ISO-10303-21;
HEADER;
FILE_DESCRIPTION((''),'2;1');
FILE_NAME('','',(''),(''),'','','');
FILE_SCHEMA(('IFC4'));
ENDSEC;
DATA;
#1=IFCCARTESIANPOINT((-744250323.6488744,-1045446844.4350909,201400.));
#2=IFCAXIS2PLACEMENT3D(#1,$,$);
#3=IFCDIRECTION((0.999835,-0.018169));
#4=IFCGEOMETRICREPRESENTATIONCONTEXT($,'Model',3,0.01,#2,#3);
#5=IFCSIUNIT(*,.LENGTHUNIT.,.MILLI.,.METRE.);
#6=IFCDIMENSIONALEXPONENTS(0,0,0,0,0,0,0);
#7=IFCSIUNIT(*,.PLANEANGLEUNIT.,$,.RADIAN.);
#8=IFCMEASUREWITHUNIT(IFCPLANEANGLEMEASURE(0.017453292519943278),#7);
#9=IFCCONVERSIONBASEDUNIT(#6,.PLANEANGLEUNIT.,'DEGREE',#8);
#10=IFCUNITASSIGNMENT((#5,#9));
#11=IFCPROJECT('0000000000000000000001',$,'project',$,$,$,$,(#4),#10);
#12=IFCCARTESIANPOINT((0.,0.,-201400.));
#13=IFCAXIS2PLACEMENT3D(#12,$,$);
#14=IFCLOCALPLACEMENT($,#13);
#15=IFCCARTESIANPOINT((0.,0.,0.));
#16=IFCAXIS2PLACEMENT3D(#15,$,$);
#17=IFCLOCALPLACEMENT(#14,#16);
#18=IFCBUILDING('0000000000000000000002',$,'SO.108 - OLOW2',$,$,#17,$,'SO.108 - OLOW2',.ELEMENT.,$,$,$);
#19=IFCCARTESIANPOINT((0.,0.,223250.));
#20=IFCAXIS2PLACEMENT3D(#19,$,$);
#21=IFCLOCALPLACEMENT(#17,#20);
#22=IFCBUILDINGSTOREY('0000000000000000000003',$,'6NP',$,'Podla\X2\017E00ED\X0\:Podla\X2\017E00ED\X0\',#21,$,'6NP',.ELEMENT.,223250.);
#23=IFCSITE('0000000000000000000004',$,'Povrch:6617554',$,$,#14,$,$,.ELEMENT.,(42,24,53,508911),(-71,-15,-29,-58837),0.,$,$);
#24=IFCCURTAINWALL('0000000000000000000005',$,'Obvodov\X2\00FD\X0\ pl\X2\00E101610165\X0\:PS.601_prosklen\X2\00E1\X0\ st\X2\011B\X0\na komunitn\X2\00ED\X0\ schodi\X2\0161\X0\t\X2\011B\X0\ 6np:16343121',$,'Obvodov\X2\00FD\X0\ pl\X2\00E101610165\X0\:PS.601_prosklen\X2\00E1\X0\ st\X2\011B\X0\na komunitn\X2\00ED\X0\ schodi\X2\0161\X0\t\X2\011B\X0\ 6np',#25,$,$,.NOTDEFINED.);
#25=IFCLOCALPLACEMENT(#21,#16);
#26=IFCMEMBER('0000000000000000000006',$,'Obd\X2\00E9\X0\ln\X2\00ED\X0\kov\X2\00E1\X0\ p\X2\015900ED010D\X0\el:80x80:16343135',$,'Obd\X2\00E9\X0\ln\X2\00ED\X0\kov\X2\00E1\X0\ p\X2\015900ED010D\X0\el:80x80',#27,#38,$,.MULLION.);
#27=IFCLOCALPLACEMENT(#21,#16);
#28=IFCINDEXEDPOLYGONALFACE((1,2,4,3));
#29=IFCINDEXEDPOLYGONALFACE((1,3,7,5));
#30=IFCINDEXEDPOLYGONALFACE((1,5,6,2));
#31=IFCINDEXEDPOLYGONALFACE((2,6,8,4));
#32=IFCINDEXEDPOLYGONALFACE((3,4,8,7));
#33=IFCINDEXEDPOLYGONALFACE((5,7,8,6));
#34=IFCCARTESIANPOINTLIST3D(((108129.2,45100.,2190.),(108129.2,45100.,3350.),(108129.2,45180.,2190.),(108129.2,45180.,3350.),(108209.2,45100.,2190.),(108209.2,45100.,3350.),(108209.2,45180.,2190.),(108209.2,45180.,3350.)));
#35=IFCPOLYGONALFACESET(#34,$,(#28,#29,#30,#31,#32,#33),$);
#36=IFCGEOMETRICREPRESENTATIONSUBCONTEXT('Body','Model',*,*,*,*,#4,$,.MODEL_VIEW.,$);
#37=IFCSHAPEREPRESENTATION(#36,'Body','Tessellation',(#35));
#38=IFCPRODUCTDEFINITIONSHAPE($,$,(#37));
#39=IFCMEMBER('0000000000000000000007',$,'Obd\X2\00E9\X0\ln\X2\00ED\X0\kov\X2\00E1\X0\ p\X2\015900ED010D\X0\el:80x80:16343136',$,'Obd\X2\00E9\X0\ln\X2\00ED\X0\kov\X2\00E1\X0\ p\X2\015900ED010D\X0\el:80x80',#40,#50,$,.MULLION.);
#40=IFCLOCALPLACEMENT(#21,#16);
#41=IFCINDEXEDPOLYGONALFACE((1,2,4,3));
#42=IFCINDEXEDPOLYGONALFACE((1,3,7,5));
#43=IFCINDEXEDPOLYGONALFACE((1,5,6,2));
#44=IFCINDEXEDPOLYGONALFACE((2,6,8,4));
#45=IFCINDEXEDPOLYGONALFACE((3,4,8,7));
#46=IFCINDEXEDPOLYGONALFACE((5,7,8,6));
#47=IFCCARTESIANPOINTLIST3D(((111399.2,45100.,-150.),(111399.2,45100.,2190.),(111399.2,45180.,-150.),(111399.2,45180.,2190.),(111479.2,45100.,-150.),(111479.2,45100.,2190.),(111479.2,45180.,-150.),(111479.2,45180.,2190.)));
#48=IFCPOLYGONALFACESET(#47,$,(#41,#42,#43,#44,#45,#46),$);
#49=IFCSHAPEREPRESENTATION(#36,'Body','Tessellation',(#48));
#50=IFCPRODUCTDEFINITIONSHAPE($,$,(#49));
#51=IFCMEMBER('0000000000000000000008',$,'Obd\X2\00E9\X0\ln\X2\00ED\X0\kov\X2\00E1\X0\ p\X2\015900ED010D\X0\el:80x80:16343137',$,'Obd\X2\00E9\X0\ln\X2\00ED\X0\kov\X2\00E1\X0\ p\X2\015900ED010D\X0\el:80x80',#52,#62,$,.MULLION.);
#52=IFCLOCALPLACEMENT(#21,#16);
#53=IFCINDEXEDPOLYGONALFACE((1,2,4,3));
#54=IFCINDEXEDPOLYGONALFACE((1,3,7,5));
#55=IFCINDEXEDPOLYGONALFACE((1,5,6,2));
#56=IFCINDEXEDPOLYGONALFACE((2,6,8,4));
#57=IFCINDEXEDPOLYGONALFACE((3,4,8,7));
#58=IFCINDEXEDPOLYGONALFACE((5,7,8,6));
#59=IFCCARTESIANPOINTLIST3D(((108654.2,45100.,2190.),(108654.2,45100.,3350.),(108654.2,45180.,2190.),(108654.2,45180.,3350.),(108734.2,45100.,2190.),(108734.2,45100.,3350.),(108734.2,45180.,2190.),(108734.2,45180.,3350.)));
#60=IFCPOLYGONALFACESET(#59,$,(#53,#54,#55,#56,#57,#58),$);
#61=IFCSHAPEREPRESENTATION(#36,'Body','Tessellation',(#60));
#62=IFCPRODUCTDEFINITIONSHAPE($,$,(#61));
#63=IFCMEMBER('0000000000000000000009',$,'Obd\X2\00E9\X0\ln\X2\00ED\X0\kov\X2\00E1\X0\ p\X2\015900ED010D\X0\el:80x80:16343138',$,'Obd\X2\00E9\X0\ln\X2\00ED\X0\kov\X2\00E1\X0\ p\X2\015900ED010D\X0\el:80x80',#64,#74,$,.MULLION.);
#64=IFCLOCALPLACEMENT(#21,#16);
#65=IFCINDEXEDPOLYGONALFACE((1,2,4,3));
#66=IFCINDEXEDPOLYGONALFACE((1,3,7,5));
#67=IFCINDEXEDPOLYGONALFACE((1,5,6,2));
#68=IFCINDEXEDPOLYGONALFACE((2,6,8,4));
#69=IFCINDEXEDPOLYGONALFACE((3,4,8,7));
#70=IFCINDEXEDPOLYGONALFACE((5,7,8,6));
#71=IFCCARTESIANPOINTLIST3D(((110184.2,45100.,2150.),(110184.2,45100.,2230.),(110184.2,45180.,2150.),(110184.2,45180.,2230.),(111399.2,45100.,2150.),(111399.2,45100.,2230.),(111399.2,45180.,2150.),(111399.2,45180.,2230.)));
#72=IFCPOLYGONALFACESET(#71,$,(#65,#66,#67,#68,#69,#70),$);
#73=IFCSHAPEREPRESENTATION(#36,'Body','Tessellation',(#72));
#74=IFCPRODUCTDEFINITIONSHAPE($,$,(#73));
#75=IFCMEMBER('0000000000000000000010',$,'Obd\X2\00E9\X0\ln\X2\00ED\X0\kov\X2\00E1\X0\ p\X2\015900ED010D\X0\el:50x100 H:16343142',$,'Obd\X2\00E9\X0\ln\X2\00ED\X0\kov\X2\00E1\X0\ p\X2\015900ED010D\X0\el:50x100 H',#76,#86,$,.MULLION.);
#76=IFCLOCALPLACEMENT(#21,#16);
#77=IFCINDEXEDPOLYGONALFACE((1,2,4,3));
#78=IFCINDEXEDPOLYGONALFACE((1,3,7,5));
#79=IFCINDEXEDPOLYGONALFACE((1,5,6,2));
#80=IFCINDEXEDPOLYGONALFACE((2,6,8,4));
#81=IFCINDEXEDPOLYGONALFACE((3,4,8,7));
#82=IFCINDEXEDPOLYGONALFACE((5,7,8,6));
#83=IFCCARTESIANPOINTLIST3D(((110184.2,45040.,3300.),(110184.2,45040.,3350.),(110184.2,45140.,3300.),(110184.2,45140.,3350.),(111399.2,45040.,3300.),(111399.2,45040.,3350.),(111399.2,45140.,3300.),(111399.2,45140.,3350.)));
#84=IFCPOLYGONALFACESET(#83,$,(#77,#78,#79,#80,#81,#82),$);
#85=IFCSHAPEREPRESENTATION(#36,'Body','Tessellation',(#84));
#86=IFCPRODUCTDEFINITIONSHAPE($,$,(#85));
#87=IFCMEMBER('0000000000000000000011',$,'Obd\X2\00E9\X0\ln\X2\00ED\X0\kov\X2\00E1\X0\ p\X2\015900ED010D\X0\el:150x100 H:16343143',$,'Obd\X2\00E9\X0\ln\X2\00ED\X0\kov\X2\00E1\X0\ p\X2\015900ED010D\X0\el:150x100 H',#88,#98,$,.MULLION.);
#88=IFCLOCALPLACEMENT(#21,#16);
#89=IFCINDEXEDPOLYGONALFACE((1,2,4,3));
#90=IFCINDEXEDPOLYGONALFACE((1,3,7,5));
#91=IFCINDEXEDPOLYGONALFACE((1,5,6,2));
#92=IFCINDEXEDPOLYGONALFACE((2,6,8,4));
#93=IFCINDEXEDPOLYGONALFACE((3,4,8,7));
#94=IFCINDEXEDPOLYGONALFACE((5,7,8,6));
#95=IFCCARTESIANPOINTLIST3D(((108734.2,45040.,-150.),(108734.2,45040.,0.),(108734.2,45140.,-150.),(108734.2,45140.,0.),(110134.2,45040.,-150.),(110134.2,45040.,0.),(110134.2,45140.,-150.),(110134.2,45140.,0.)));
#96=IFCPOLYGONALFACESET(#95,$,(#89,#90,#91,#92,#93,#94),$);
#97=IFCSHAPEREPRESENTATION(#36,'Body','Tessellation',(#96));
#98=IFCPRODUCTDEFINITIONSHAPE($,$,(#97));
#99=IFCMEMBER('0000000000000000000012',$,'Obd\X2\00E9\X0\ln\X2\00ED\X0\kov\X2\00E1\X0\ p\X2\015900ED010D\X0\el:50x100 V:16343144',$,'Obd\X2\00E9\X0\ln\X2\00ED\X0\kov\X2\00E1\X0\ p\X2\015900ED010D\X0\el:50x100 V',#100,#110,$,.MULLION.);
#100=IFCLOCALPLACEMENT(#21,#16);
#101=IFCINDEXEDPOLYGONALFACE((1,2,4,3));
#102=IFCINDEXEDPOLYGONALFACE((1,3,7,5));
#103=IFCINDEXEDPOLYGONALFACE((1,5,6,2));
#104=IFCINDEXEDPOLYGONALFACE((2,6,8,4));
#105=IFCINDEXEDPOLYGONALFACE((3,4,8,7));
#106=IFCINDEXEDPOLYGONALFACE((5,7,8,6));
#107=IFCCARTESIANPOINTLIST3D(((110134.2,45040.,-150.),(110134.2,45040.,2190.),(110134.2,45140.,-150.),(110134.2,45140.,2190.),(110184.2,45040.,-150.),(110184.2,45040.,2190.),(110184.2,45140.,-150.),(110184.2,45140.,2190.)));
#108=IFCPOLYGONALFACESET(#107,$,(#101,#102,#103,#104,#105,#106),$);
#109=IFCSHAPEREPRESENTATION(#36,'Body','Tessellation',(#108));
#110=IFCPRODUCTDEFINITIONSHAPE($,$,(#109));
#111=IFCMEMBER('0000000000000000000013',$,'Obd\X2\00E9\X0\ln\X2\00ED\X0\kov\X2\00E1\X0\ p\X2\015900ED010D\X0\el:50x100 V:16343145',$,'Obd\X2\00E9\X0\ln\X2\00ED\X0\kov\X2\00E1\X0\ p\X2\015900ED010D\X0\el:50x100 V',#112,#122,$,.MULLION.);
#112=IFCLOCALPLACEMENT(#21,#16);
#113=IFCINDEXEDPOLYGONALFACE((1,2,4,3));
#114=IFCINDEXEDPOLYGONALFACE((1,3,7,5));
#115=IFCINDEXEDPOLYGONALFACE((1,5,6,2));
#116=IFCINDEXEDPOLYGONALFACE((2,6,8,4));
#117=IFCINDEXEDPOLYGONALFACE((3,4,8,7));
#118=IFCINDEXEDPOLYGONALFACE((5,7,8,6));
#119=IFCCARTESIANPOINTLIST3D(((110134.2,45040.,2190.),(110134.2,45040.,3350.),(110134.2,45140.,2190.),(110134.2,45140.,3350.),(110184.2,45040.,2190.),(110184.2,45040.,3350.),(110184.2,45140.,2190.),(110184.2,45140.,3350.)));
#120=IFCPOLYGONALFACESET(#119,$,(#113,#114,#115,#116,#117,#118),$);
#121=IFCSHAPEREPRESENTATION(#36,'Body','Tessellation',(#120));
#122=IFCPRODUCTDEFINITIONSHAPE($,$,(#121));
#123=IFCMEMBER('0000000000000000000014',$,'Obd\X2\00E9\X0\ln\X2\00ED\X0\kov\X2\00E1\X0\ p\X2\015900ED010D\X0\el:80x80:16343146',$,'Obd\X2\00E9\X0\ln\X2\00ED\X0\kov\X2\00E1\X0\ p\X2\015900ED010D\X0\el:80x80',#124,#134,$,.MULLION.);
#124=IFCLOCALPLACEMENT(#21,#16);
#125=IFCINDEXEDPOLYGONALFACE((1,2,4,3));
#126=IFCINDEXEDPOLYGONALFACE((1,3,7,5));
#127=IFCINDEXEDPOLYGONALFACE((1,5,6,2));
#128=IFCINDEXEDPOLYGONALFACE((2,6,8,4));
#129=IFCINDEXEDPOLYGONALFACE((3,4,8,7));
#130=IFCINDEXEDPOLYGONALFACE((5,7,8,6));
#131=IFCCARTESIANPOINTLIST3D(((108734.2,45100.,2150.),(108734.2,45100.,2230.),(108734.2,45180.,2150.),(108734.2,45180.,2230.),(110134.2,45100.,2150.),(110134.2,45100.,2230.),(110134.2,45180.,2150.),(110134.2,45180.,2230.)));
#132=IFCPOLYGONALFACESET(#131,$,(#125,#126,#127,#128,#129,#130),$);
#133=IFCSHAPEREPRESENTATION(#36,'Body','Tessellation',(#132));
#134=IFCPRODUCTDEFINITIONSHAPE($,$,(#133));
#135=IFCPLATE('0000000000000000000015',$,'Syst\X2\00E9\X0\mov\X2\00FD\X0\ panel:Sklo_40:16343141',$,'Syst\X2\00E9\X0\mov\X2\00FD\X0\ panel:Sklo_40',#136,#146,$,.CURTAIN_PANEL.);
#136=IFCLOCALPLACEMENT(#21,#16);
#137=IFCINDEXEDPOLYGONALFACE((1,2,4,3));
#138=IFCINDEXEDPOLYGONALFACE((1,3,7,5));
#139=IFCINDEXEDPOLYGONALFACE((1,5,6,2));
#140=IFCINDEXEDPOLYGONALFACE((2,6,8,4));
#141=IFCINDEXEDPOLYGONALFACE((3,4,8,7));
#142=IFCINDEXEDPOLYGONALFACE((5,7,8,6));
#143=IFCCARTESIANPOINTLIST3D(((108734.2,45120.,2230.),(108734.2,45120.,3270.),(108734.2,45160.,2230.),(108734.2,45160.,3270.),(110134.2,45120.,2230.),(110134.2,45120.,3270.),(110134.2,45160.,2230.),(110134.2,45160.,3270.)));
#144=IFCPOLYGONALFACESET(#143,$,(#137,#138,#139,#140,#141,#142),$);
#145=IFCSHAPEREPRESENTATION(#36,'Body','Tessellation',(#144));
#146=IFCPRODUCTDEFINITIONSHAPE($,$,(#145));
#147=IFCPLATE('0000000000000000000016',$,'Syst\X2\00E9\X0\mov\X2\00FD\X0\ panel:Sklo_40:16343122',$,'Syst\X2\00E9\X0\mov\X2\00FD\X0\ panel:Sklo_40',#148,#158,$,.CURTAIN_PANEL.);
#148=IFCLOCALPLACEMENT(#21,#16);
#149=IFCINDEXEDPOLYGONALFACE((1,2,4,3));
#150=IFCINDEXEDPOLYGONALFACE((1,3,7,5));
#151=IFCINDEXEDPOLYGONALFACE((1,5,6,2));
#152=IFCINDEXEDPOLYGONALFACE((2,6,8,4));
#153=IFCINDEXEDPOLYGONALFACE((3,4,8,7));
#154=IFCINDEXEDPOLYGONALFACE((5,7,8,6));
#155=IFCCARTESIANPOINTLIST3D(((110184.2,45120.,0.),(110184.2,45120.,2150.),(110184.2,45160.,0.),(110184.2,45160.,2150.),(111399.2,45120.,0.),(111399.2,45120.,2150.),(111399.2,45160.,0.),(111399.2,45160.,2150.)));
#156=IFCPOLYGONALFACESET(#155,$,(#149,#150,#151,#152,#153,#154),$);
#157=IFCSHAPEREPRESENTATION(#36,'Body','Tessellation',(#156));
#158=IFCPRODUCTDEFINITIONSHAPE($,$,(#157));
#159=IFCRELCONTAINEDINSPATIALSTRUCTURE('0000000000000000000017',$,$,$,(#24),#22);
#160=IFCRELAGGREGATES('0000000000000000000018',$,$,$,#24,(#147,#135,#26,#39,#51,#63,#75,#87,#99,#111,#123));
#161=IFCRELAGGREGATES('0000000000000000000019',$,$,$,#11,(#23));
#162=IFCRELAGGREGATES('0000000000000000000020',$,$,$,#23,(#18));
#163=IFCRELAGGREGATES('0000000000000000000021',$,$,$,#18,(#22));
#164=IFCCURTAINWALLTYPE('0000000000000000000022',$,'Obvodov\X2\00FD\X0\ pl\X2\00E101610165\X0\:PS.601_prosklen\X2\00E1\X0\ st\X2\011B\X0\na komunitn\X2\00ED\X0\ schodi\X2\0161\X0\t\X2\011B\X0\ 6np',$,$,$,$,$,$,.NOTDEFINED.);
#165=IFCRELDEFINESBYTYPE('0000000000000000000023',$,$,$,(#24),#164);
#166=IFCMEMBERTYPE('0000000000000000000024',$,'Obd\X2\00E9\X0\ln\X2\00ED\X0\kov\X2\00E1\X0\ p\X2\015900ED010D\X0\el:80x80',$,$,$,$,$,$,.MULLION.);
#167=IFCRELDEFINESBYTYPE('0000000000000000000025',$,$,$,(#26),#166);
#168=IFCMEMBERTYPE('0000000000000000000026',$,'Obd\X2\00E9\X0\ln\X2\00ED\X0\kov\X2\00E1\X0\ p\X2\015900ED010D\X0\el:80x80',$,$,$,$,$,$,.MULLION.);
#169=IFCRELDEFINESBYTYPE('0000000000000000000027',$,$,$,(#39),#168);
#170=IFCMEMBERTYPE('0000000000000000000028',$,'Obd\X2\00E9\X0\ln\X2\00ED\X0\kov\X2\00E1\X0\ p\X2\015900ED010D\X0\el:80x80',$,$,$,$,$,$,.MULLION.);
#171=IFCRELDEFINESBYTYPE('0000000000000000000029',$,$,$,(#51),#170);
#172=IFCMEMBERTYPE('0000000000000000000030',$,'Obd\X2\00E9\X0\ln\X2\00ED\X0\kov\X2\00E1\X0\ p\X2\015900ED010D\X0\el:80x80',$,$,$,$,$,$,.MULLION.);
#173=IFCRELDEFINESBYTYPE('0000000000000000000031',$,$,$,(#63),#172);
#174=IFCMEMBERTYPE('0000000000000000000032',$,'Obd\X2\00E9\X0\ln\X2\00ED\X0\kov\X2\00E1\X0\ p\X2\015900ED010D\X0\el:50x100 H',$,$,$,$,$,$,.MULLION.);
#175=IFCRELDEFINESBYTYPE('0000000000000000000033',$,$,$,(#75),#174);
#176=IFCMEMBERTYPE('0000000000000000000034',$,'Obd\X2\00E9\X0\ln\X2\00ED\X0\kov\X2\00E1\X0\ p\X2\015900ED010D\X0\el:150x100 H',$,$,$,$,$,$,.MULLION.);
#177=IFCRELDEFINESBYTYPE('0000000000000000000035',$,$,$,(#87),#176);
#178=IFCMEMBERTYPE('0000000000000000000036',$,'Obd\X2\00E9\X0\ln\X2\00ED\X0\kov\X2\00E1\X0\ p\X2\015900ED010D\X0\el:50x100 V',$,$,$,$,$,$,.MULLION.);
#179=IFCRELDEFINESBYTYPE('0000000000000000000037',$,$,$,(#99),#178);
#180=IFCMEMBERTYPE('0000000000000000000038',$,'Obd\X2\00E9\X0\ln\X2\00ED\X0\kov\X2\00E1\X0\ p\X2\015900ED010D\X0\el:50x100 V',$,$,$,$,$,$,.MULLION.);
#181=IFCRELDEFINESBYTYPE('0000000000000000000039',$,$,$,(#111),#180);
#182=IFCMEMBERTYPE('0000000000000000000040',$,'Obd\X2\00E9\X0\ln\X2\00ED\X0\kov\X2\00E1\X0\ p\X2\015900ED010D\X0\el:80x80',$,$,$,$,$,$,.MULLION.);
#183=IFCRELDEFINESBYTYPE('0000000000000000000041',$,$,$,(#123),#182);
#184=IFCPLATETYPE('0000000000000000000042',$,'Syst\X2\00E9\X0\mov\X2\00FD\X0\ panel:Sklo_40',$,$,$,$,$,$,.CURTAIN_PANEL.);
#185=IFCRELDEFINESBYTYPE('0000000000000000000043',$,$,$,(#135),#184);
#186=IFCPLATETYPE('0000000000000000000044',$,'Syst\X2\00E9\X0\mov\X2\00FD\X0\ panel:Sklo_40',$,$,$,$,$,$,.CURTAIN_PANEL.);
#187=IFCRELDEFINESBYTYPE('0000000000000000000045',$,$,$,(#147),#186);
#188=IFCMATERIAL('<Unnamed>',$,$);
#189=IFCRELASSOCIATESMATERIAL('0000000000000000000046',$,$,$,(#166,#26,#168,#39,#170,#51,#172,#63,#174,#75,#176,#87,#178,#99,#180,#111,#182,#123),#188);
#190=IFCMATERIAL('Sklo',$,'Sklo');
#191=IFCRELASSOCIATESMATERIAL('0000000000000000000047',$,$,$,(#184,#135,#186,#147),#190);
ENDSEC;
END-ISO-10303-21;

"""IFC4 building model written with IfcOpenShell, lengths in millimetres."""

from ifc_helpers import new_model, entity, si_unit, converted_unit, direction, frame, origin, place, context, subcontext, project, spatial, indexed_curve, outline, extrude, source, transform, mapped, material, type_object, type_shapes, element, aggregate, save


model = new_model("IFC4")

# Units and contexts
model_context = context("Model", 3, precision=0.01, world=frame((-744250323.6488744, -1045446844.4350909, 201400.0)), true_north=direction((0.999835, -0.018169)))
body_context = subcontext(model_context, "Body", "Model", "MODEL_VIEW")
ifc_project = project(units=[si_unit("LENGTHUNIT", "METRE", prefix="MILLI"), converted_unit("PLANEANGLEUNIT", "DEGREE", entity("IfcPlaneAngleMeasure", 0.017453292519943278), si_unit("PLANEANGLEUNIT", "RADIAN"), dimensions=[0, 0, 0, 0, 0, 0, 0])], contexts=[model_context])

# Site, building, storey
site_placement = place(None, frame((0.0, 0.0, -201400.0)))
site = spatial("IfcSite", under=ifc_project, at=site_placement, Name="Povrch:6617554", CompositionType="ELEMENT", RefLatitude=(42, 24, 53, 508911), RefLongitude=(-71, -15, -29, -58837), RefElevation=0.0)
building_placement = place(site_placement, origin())
building = spatial("IfcBuilding", under=site, at=building_placement, Name="SO.108 - OLOW2", LongName="SO.108 - OLOW2", CompositionType="ELEMENT")
storey_placement = place(building_placement, frame((0.0, 0.0, 223250.0)))
storey = spatial("IfcBuildingStorey", under=building, at=storey_placement, Name="6NP", ObjectType="Podlaží:Podlaží", LongName="6NP", CompositionType="ELEMENT", Elevation=223250.0)

# Shared definitions
ifc_material_1 = material(Name="<Unnamed>")

# Curtain wall, members, plates
curtain_wall_type_1 = type_object("IfcCurtainWallType", Name="Obvodový plášť:PS.601_prosklená stěna komunitní schodiště 6np", PredefinedType="NOTDEFINED")
curtain_wall_1_placement = place(storey_placement, frame((0.0, 0.0, -223250.0)))
curtain_wall_1 = element("IfcCurtainWall", 1, at=curtain_wall_1_placement, inside=storey, type_object=curtain_wall_type_1, Name="Obvodový plášť:PS.601_prosklená stěna komunitní schodiště 6np:16343121", ObjectType="Obvodový plášť:PS.601_prosklená stěna komunitní schodiště 6np", PredefinedType="NOTDEFINED")
member_type_1 = type_object("IfcMemberType", Name="Obdélníková příčel:80x80", PredefinedType="MULLION", material=ifc_material_1)
shared_shape_1 = source(origin(), body_context, "Body", "SweptSolid", [
    extrude(outline(indexed_curve([(-40.0, -40.0), (40.0, -40.0), (40.0, 40.0), (-40.0, 40.0), (-40.0, -40.0)], self_intersect=False)), frame((-40.0, 0.0, -1160.0), z_axis=(0.0, 0.0, 1.0), x_axis=(-1.0, 0.0, 0.0)), (0.0, 0.0, 1.0), 1160.0),
])
type_shapes(member_type_1, [shared_shape_1])
member_1_placement = place(curtain_wall_1_placement, frame((108129.2, 45140.0, 225440.0), z_axis=(0.0, 0.0, -1.0), x_axis=(-1.0, 0.0, 0.0)))
member_1 = element("IfcMember", 2, at=member_1_placement, type_object=member_type_1, material=ifc_material_1, Name="Obdélníková příčel:80x80:16343135", ObjectType="Obdélníková příčel:80x80", PredefinedType="MULLION", context=body_context, shape_type="MappedRepresentation", body=[
    mapped(shared_shape_1, transform((0.0, 0.0, 0.0), scale=1.0)),
])
member_type_2 = type_object("IfcMemberType", Name="Obdélníková příčel:80x80", PredefinedType="MULLION", material=ifc_material_1)
shared_shape_2 = source(origin(), body_context, "Body", "SweptSolid", [
    extrude(outline(indexed_curve([(-40.0, -40.0), (40.0, -40.0), (40.0, 40.0), (-40.0, 40.0), (-40.0, -40.0)], self_intersect=False)), frame((-40.0, 0.0, -2340.0), z_axis=(0.0, 0.0, 1.0), x_axis=(-1.0, 0.0, 0.0)), (0.0, 0.0, 1.0), 2340.0),
])
type_shapes(member_type_2, [shared_shape_2])
member_2_placement = place(curtain_wall_1_placement, frame((111479.2, 45140.0, 225440.0)))
member_2 = element("IfcMember", 3, at=member_2_placement, type_object=member_type_2, material=ifc_material_1, Name="Obdélníková příčel:80x80:16343136", ObjectType="Obdélníková příčel:80x80", PredefinedType="MULLION", context=body_context, shape_type="MappedRepresentation", body=[
    mapped(shared_shape_2, transform((0.0, 0.0, 0.0), scale=1.0)),
])
member_type_3 = type_object("IfcMemberType", Name="Obdélníková příčel:80x80", PredefinedType="MULLION", material=ifc_material_1)
shared_shape_3 = source(origin(), body_context, "Body", "SweptSolid", [
    extrude(outline(indexed_curve([(-40.0, -40.0), (40.0, -40.0), (40.0, 40.0), (-40.0, 40.0), (-40.0, -40.0)], self_intersect=False)), frame((0.0, 0.0, -1160.0), z_axis=(0.0, 0.0, 1.0), x_axis=(-1.0, 0.0, 0.0)), (0.0, 0.0, 1.0), 1160.0),
])
type_shapes(member_type_3, [shared_shape_3])
member_3_placement = place(curtain_wall_1_placement, frame((108694.2, 45140.0, 225440.0), z_axis=(0.0, 0.0, -1.0), x_axis=(-1.0, 0.0, 0.0)))
member_3 = element("IfcMember", 4, at=member_3_placement, type_object=member_type_3, material=ifc_material_1, Name="Obdélníková příčel:80x80:16343137", ObjectType="Obdélníková příčel:80x80", PredefinedType="MULLION", context=body_context, shape_type="MappedRepresentation", body=[
    mapped(shared_shape_3, transform((0.0, 0.0, 0.0), scale=1.0)),
])
member_type_4 = type_object("IfcMemberType", Name="Obdélníková příčel:80x80", PredefinedType="MULLION", material=ifc_material_1)
shared_shape_4 = source(origin(), body_context, "Body", "SweptSolid", [
    extrude(outline(indexed_curve([(-40.0, -40.0), (40.0, -40.0), (40.0, 40.0), (-40.0, 40.0), (-40.0, -40.0)], self_intersect=False)), frame((0.0, 0.0, -1215.0), z_axis=(0.0, 0.0, 1.0), x_axis=(-1.0, 0.0, 0.0)), (0.0, 0.0, 1.0), 1215.0),
])
type_shapes(member_type_4, [shared_shape_4])
member_4_placement = place(curtain_wall_1_placement, frame((110184.2, 45140.0, 225440.0), z_axis=(-1.0, 0.0, 0.0), x_axis=(0.0, 0.0, 1.0)))
member_4 = element("IfcMember", 5, at=member_4_placement, type_object=member_type_4, material=ifc_material_1, Name="Obdélníková příčel:80x80:16343138", ObjectType="Obdélníková příčel:80x80", PredefinedType="MULLION", context=body_context, shape_type="MappedRepresentation", body=[
    mapped(shared_shape_4, transform((0.0, 0.0, 0.0), scale=1.0)),
])
member_type_5 = type_object("IfcMemberType", Name="Obdélníková příčel:50x100 H", PredefinedType="MULLION", material=ifc_material_1)
shared_shape_5 = source(origin(), body_context, "Body", "SweptSolid", [
    extrude(outline(indexed_curve([(-25.0, -50.0), (25.0, -50.0), (25.0, 50.0), (-25.0, 50.0), (-25.0, -50.0)], self_intersect=False)), frame((-25.0, -50.0, -1215.0), z_axis=(0.0, 0.0, 1.0), x_axis=(-1.0, 0.0, 0.0)), (0.0, 0.0, 1.0), 1215.0),
])
type_shapes(member_type_5, [shared_shape_5])
member_5_placement = place(curtain_wall_1_placement, frame((110184.2, 45140.0, 226600.0), z_axis=(-1.0, 0.0, 0.0), x_axis=(0.0, 0.0, 1.0)))
member_5 = element("IfcMember", 6, at=member_5_placement, type_object=member_type_5, material=ifc_material_1, Name="Obdélníková příčel:50x100 H:16343142", ObjectType="Obdélníková příčel:50x100 H", PredefinedType="MULLION", context=body_context, shape_type="MappedRepresentation", body=[
    mapped(shared_shape_5, transform((0.0, 0.0, 0.0), scale=1.0)),
])
member_type_6 = type_object("IfcMemberType", Name="Obdélníková příčel:150x100 H", PredefinedType="MULLION", material=ifc_material_1)
shared_shape_6 = source(origin(), body_context, "Body", "SweptSolid", [
    extrude(outline(indexed_curve([(-75.0, -50.0), (75.0, -50.0), (75.0, 50.0), (-75.0, 50.0), (-75.0, -50.0)], self_intersect=False)), frame((-75.0, -50.0, -1400.0), z_axis=(0.0, 0.0, 1.0), x_axis=(-1.0, 0.0, 0.0)), (0.0, 0.0, 1.0), 1400.0),
])
type_shapes(member_type_6, [shared_shape_6])
member_6_placement = place(curtain_wall_1_placement, frame((110134.2, 45140.0, 223100.0), z_axis=(1.0, 0.0, 0.0), x_axis=(0.0, 0.0, -1.0)))
member_6 = element("IfcMember", 7, at=member_6_placement, type_object=member_type_6, material=ifc_material_1, Name="Obdélníková příčel:150x100 H:16343143", ObjectType="Obdélníková příčel:150x100 H", PredefinedType="MULLION", context=body_context, shape_type="MappedRepresentation", body=[
    mapped(shared_shape_6, transform((0.0, 0.0, 0.0), scale=1.0)),
])
member_type_7 = type_object("IfcMemberType", Name="Obdélníková příčel:50x100 V", PredefinedType="MULLION", material=ifc_material_1)
shared_shape_7 = source(origin(), body_context, "Body", "SweptSolid", [
    extrude(outline(indexed_curve([(-25.0, -50.0), (25.0, -50.0), (25.0, 50.0), (-25.0, 50.0), (-25.0, -50.0)], self_intersect=False)), frame((0.0, -50.0, -2340.0), z_axis=(0.0, 0.0, 1.0), x_axis=(-1.0, 0.0, 0.0)), (0.0, 0.0, 1.0), 2340.0),
])
type_shapes(member_type_7, [shared_shape_7])
member_7_placement = place(curtain_wall_1_placement, frame((110159.2, 45140.0, 223100.0), z_axis=(0.0, 0.0, -1.0), x_axis=(-1.0, 0.0, 0.0)))
member_7 = element("IfcMember", 8, at=member_7_placement, type_object=member_type_7, material=ifc_material_1, Name="Obdélníková příčel:50x100 V:16343144", ObjectType="Obdélníková příčel:50x100 V", PredefinedType="MULLION", context=body_context, shape_type="MappedRepresentation", body=[
    mapped(shared_shape_7, transform((0.0, 0.0, 0.0), scale=1.0)),
])
member_type_8 = type_object("IfcMemberType", Name="Obdélníková příčel:50x100 V", PredefinedType="MULLION", material=ifc_material_1)
shared_shape_8 = source(origin(), body_context, "Body", "SweptSolid", [
    extrude(outline(indexed_curve([(-25.0, -50.0), (25.0, -50.0), (25.0, 50.0), (-25.0, 50.0), (-25.0, -50.0)], self_intersect=False)), frame((0.0, -50.0, -1160.0), z_axis=(0.0, 0.0, 1.0), x_axis=(-1.0, 0.0, 0.0)), (0.0, 0.0, 1.0), 1160.0),
])
type_shapes(member_type_8, [shared_shape_8])
member_8_placement = place(curtain_wall_1_placement, frame((110159.2, 45140.0, 225440.0), z_axis=(0.0, 0.0, -1.0), x_axis=(-1.0, 0.0, 0.0)))
member_8 = element("IfcMember", 9, at=member_8_placement, type_object=member_type_8, material=ifc_material_1, Name="Obdélníková příčel:50x100 V:16343145", ObjectType="Obdélníková příčel:50x100 V", PredefinedType="MULLION", context=body_context, shape_type="MappedRepresentation", body=[
    mapped(shared_shape_8, transform((0.0, 0.0, 0.0), scale=1.0)),
])
member_type_9 = type_object("IfcMemberType", Name="Obdélníková příčel:80x80", PredefinedType="MULLION", material=ifc_material_1)
shared_shape_9 = source(origin(), body_context, "Body", "SweptSolid", [
    extrude(outline(indexed_curve([(-40.0, -40.0), (40.0, -40.0), (40.0, 40.0), (-40.0, 40.0), (-40.0, -40.0)], self_intersect=False)), frame((0.0, 0.0, -1400.0), z_axis=(0.0, 0.0, 1.0), x_axis=(-1.0, 0.0, 0.0)), (0.0, 0.0, 1.0), 1400.0),
])
type_shapes(member_type_9, [shared_shape_9])
member_9_placement = place(curtain_wall_1_placement, frame((108734.2, 45140.0, 225440.0), z_axis=(-1.0, 0.0, 0.0), x_axis=(0.0, 0.0, 1.0)))
member_9 = element("IfcMember", 10, at=member_9_placement, type_object=member_type_9, material=ifc_material_1, Name="Obdélníková příčel:80x80:16343146", ObjectType="Obdélníková příčel:80x80", PredefinedType="MULLION", context=body_context, shape_type="MappedRepresentation", body=[
    mapped(shared_shape_9, transform((0.0, 0.0, 0.0), scale=1.0)),
])
ifc_material_2 = material(Name="Sklo", Category="Sklo")
plate_type_1 = type_object("IfcPlateType", Name="Systémový panel:Sklo_40", PredefinedType="CURTAIN_PANEL", material=ifc_material_2)
shared_shape_10 = source(origin(), body_context, "Body", "SweptSolid", [
    extrude(outline(indexed_curve([(-20.0, -700.0), (20.0, -700.0), (20.0, 700.0), (-20.0, 700.0), (-20.0, -700.0)], self_intersect=False)), frame((0.0, 0.0, 0.0), z_axis=(0.0, 0.0, 1.0), x_axis=(0.0, 1.0, 0.0)), (0.0, 0.0, 1.0), 1040.0),
])
type_shapes(plate_type_1, [shared_shape_10])
plate_1_placement = place(curtain_wall_1_placement, frame((109434.2, 45140.0, 225480.0), z_axis=(0.0, 0.0, 1.0), x_axis=(-1.0, 0.0, 0.0)))
plate_1 = element("IfcPlate", 11, at=plate_1_placement, type_object=plate_type_1, material=ifc_material_2, Name="Systémový panel:Sklo_40:16343141", ObjectType="Systémový panel:Sklo_40", PredefinedType="CURTAIN_PANEL", context=body_context, shape_type="MappedRepresentation", body=[
    mapped(shared_shape_10, transform((0.0, 0.0, 0.0), scale=1.0)),
])
plate_type_2 = type_object("IfcPlateType", Name="Systémový panel:Sklo_40", PredefinedType="CURTAIN_PANEL", material=ifc_material_2)
shared_shape_11 = source(origin(), body_context, "Body", "SweptSolid", [
    extrude(outline(indexed_curve([(-20.0, -607.5), (20.0, -607.5), (20.0, 607.5), (-20.0, 607.5), (-20.0, -607.5)], self_intersect=False)), frame((0.0, 0.0, 0.0), z_axis=(0.0, 0.0, 1.0), x_axis=(0.0, 1.0, 0.0)), (0.0, 0.0, 1.0), 2150.0),
])
type_shapes(plate_type_2, [shared_shape_11])
plate_2_placement = place(curtain_wall_1_placement, frame((110791.7, 45140.0, 223250.0), z_axis=(0.0, 0.0, 1.0), x_axis=(-1.0, 0.0, 0.0)))
plate_2 = element("IfcPlate", 12, at=plate_2_placement, type_object=plate_type_2, material=ifc_material_2, Name="Systémový panel:Sklo_40:16343122", ObjectType="Systémový panel:Sklo_40", PredefinedType="CURTAIN_PANEL", context=body_context, shape_type="MappedRepresentation", body=[
    mapped(shared_shape_11, transform((0.0, 0.0, 0.0), scale=1.0)),
])
aggregate(curtain_wall_1, [plate_2, plate_1, member_1, member_2, member_3, member_4, member_5, member_6, member_7, member_8, member_9])

save(model, "model.ifc")
